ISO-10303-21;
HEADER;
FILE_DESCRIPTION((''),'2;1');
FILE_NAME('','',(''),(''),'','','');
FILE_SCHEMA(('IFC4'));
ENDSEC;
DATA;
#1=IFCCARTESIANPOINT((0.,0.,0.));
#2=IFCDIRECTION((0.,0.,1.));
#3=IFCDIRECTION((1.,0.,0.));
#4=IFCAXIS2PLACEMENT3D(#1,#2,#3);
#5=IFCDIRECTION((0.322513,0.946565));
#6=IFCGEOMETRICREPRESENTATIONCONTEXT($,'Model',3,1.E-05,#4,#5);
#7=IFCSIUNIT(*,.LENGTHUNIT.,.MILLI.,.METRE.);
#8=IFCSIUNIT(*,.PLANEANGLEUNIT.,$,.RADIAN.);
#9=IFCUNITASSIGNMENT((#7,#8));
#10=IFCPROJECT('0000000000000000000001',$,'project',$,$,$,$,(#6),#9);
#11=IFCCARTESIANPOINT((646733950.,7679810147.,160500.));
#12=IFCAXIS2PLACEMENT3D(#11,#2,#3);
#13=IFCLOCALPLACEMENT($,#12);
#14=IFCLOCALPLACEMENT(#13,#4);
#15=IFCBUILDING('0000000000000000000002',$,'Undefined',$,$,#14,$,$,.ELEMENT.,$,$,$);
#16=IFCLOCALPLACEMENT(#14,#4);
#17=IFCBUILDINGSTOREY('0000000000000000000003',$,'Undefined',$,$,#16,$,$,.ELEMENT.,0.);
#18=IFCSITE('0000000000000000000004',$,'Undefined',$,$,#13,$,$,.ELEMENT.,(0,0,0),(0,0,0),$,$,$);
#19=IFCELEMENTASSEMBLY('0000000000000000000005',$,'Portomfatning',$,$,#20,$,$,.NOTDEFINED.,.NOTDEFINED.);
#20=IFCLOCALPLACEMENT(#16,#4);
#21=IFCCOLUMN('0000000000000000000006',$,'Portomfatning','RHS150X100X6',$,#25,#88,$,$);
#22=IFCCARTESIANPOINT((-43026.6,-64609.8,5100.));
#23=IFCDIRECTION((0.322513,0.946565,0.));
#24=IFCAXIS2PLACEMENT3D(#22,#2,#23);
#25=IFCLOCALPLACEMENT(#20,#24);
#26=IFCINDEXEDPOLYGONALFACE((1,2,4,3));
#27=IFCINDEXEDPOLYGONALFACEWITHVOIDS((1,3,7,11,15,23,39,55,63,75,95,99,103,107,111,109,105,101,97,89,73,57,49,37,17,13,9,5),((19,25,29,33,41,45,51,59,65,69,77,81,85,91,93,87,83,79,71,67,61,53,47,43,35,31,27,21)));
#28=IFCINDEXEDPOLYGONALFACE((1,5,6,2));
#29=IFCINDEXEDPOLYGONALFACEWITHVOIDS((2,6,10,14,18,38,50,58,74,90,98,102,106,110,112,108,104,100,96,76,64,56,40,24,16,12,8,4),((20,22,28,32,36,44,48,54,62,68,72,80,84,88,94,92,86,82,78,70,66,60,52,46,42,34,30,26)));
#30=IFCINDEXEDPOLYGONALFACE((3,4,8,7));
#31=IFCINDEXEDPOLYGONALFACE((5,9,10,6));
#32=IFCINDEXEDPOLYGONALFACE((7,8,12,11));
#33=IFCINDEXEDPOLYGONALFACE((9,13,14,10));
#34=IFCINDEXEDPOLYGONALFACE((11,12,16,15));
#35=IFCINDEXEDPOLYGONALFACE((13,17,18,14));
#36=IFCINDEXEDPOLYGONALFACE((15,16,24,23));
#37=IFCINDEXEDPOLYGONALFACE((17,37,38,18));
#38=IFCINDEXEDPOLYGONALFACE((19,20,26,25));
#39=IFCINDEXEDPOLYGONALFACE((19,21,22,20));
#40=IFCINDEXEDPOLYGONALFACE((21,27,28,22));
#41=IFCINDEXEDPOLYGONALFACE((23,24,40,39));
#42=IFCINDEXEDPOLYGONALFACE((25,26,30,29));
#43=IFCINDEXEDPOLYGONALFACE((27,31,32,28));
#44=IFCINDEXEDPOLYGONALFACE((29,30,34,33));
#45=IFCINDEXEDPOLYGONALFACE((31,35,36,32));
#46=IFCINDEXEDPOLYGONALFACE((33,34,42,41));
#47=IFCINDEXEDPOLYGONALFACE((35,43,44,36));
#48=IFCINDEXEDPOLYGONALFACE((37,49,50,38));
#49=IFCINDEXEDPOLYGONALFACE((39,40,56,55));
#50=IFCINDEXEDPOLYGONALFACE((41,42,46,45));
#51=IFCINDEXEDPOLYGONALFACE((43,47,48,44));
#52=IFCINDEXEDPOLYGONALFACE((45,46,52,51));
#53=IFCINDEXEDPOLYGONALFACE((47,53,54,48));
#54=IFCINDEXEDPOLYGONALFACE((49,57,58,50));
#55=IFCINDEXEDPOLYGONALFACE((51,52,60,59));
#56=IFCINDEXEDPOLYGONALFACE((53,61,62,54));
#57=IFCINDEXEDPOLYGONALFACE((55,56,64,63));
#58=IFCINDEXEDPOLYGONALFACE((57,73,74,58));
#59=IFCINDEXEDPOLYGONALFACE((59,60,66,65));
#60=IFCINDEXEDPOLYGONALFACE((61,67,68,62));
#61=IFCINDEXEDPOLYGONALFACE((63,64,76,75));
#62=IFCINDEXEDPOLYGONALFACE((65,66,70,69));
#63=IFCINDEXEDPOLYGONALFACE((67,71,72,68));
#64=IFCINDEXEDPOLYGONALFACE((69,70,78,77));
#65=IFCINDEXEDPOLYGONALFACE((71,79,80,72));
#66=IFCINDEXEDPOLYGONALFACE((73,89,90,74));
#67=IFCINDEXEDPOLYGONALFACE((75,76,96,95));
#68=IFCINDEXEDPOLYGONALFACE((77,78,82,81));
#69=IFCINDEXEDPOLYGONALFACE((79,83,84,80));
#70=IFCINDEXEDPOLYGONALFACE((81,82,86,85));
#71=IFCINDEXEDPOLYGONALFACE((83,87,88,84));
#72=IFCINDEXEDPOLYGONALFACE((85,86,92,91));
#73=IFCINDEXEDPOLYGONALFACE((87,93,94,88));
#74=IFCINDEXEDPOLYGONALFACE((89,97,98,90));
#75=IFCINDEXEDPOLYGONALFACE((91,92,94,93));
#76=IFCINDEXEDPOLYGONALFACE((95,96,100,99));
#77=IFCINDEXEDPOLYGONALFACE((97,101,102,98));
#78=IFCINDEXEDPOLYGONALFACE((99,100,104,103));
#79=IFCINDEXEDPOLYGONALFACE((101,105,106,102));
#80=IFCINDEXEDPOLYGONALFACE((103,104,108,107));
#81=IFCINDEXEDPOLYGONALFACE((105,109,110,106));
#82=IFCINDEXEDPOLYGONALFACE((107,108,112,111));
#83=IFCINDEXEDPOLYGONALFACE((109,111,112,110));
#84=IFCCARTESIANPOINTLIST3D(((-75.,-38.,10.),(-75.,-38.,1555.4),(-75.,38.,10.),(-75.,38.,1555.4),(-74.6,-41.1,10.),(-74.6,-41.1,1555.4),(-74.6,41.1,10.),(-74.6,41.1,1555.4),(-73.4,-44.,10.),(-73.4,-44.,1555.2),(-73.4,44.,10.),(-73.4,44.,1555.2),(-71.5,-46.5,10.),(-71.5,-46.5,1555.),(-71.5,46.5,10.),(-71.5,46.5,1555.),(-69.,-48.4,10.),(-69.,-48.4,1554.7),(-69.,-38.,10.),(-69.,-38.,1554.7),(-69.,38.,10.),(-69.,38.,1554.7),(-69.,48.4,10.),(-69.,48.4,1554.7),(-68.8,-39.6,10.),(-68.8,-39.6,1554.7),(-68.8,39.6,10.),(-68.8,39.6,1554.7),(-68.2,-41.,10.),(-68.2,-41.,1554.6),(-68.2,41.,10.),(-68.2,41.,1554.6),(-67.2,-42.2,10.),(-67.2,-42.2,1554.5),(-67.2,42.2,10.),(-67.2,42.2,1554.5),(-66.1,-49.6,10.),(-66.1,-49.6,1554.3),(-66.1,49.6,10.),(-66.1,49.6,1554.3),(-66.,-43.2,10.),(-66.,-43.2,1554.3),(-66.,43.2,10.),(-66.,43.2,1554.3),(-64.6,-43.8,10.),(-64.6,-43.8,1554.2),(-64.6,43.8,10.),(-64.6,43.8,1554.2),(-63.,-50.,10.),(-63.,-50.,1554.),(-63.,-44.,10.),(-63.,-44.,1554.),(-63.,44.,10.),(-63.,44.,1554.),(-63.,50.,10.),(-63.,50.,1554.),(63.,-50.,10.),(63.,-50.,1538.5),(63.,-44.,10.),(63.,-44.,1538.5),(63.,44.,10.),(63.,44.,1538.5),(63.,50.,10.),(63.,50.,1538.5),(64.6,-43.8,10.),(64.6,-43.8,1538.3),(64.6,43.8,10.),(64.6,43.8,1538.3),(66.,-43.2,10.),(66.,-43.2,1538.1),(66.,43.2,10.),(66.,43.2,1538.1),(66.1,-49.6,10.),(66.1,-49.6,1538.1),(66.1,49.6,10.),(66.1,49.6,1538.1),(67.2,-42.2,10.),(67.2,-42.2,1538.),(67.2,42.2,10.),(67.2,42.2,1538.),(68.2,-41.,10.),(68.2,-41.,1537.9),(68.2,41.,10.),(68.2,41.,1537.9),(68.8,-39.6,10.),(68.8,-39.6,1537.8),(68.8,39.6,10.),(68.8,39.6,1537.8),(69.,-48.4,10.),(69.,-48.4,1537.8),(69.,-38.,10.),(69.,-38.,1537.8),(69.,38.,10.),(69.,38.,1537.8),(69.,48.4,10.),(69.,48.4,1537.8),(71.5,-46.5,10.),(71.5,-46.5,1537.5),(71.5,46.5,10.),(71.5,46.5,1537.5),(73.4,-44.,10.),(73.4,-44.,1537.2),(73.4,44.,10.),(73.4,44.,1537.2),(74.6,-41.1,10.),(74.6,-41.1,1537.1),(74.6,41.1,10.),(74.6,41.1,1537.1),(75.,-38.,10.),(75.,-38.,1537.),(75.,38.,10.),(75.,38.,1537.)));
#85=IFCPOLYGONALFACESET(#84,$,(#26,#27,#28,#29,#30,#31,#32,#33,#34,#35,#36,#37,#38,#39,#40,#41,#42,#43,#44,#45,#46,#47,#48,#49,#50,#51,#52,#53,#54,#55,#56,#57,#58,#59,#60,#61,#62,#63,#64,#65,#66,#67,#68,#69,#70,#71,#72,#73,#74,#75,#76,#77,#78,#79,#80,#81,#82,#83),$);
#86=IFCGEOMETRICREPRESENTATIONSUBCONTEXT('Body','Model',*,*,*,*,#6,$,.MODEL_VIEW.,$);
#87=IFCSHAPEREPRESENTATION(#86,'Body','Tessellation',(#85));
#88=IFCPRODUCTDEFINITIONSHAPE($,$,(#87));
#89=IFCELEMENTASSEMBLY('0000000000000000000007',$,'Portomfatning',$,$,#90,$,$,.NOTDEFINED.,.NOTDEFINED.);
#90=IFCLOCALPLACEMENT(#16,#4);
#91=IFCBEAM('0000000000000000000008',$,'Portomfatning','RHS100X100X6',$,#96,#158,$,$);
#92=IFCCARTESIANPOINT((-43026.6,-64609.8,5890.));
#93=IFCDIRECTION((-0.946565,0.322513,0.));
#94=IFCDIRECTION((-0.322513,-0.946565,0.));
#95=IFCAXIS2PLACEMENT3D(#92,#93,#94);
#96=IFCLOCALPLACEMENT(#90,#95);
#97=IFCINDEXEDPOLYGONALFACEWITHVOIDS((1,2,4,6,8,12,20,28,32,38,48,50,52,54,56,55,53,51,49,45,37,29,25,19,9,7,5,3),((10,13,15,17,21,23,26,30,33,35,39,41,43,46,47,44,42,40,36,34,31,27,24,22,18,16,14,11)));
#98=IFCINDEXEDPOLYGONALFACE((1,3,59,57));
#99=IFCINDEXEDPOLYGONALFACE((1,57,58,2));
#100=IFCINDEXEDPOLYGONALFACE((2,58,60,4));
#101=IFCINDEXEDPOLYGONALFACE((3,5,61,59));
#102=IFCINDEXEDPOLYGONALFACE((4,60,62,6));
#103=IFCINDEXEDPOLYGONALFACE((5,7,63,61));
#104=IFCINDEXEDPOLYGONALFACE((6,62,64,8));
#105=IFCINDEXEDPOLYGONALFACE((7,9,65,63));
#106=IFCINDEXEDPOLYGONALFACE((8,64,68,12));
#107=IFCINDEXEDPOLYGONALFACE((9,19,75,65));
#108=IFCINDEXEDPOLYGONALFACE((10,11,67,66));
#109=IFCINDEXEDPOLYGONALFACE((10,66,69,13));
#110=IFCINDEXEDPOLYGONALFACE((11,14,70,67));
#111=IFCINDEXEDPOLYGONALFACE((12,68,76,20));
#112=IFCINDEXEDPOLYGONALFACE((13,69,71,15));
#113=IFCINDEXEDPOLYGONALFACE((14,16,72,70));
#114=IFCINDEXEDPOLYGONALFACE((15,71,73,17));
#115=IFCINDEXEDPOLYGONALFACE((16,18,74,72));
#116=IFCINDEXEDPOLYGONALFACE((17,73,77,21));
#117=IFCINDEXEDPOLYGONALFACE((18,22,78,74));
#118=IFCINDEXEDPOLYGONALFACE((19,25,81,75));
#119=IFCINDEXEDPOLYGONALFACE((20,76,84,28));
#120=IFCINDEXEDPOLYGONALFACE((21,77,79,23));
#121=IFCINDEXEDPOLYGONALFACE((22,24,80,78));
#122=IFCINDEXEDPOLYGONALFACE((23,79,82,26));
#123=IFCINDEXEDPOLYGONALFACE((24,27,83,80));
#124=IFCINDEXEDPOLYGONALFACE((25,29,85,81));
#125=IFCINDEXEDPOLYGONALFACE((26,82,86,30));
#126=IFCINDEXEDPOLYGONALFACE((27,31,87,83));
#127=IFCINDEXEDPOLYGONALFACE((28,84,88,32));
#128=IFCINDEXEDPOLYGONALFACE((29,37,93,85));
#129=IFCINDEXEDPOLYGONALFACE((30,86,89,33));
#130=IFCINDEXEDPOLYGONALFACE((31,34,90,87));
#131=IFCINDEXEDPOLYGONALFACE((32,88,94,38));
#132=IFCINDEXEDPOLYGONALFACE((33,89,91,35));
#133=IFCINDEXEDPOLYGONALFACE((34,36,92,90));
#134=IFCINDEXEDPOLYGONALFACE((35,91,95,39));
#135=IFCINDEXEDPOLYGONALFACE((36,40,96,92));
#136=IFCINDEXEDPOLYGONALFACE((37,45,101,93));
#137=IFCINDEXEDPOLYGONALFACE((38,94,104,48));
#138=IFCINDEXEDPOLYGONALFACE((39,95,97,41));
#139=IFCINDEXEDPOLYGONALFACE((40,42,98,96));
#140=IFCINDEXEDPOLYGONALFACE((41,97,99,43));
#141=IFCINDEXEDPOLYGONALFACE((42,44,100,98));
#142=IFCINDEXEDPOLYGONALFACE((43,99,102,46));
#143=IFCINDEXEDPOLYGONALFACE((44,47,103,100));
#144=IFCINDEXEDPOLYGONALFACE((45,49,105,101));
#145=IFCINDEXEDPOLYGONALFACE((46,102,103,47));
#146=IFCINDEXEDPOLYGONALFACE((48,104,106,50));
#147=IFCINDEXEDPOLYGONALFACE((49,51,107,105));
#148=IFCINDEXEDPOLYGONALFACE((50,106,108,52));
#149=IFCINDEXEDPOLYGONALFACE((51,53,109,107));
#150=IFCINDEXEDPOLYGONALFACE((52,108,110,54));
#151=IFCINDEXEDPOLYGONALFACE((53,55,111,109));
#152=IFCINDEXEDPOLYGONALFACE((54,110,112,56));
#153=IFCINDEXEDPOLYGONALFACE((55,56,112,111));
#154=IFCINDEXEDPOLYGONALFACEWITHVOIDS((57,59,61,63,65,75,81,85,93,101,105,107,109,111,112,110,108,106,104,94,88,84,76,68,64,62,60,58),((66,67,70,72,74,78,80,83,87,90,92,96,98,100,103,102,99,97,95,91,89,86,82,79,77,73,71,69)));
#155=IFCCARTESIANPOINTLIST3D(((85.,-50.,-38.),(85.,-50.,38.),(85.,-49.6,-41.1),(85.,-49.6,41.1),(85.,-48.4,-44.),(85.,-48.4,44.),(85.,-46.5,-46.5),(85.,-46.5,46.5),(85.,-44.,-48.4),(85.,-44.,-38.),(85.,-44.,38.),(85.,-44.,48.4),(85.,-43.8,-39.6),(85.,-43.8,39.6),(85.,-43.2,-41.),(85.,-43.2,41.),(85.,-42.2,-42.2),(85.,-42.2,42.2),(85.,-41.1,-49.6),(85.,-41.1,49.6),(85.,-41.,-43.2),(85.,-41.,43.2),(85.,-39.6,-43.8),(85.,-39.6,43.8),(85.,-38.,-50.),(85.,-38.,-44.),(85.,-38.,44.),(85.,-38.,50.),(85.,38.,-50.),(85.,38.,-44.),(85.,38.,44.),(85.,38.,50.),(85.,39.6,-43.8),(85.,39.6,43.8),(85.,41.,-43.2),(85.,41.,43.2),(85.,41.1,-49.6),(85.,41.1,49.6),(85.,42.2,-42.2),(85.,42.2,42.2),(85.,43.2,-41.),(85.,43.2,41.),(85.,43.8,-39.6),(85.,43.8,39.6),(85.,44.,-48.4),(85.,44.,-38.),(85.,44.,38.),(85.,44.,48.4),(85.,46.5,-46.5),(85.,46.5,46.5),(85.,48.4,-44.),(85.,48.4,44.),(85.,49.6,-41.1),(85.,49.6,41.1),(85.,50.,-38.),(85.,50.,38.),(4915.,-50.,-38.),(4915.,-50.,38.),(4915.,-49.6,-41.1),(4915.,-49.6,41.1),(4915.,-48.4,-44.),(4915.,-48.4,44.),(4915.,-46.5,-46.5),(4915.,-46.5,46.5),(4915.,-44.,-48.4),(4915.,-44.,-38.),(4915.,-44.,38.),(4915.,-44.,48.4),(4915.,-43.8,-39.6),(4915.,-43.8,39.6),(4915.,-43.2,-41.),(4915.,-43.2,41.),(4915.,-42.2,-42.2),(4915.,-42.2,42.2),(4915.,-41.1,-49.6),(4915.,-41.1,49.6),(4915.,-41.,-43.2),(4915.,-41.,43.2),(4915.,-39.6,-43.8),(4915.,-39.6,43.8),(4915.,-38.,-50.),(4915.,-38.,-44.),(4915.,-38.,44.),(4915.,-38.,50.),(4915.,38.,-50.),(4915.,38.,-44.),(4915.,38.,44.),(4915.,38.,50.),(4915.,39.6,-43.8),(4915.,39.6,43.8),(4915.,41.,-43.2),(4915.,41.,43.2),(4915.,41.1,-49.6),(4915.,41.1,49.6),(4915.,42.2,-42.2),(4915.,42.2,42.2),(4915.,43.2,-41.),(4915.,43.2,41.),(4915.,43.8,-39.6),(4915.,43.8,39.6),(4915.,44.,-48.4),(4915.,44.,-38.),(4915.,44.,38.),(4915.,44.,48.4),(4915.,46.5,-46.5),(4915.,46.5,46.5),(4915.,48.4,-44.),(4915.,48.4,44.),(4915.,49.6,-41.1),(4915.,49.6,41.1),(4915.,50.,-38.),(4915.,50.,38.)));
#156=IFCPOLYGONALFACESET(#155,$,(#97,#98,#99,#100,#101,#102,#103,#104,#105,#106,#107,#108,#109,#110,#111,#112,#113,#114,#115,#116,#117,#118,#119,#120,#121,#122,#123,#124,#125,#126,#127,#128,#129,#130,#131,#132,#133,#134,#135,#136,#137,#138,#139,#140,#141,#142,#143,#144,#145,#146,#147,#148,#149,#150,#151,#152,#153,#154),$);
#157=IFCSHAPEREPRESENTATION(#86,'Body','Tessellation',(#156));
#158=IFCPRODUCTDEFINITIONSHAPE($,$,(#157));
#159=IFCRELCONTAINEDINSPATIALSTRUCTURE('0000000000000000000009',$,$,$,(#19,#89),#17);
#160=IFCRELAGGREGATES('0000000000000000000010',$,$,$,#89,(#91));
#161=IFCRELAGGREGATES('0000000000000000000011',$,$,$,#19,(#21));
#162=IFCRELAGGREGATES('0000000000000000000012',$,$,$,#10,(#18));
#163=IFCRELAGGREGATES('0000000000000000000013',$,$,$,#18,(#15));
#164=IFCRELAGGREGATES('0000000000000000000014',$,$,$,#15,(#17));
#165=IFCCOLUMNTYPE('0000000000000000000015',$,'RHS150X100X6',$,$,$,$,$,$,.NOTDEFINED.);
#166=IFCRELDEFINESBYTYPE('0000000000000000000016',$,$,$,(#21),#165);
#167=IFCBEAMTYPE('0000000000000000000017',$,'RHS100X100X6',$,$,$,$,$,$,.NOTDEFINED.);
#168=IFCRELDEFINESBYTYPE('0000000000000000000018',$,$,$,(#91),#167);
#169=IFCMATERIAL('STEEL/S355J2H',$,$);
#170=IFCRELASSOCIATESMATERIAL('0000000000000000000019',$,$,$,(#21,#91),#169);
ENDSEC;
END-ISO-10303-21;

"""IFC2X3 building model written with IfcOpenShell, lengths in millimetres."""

from ifc_helpers import new_model, si_unit, direction, frame, origin_with_axes, origin_2d_with_axis, place, context, subcontext, project, spatial, hollow_rectangle, extrude, clip, halfspace, material, type_object, element, aggregate, save


model = new_model("IFC2X3")

# Units and contexts
model_context = context("Model", 3, precision=1e-05, world=origin_with_axes(), true_north=direction((0.322513, 0.946565)))
body_context = subcontext(model_context, "Body", "Model", "MODEL_VIEW")
ifc_project = project(units=[si_unit("LENGTHUNIT", "METRE", prefix="MILLI"), si_unit("PLANEANGLEUNIT", "RADIAN")], contexts=[model_context])

# Site, building, storey
site_placement = place(None, frame((646733950.0, 7679810147.0, 160500.0), z_axis=(0.0, 0.0, 1.0), x_axis=(1.0, 0.0, 0.0)))
site = spatial("IfcSite", under=ifc_project, at=site_placement, Name="Undefined", CompositionType="ELEMENT", RefLatitude=(0, 0, 0), RefLongitude=(0, 0, 0))
building_placement = place(site_placement, origin_with_axes())
building = spatial("IfcBuilding", under=site, at=building_placement, Name="Undefined", CompositionType="ELEMENT")
storey_placement = place(building_placement, origin_with_axes())
storey = spatial("IfcBuildingStorey", under=building, at=storey_placement, Name="Undefined", CompositionType="ELEMENT", Elevation=0.0)

# Element assembly, column
assembly_1_placement = place(storey_placement, origin_with_axes())
assembly_1 = element("IfcElementAssembly", 1, at=assembly_1_placement, inside=storey, Name="Portomfatning", AssemblyPlace="NOTDEFINED", PredefinedType="NOTDEFINED")
ifc_material_1 = material(Name="STEEL/S355J2H")
column_type = type_object("IfcColumnType", Name="RHS150X100X6", PredefinedType="NOTDEFINED")
column_placement = place(assembly_1_placement, frame((-43026.6, -64609.8, 5100.0), z_axis=(0.0, 0.0, 1.0), x_axis=(0.322513, 0.946565, 0.0)))
column = element("IfcColumn", 2, at=column_placement, type_object=column_type, material=ifc_material_1, Name="Portomfatning", Description="RHS150X100X6", context=body_context, shape_type="Clipping", body=[
    clip(clip(extrude(hollow_rectangle(XDim=100.0, YDim=150.0, WallThickness=6.0, InnerFilletRadius=6.0, OuterFilletRadius=12.0, at=origin_2d_with_axis()), frame((0.0, 0.0, 1561.3), z_axis=(0.0, 0.0, -1.0), x_axis=(0.0, 1.0, 0.0)), (0.0, 0.0, 1.0), 1561.3), halfspace(frame((75.0, 0.0, 1537.0), z_axis=(-0.121869, 0.0, -0.992546), x_axis=(0.0, 1.0, 0.0)), True)), halfspace(frame((-75.0, 0.0, 10.0), z_axis=(0.0, 0.0, 1.0), x_axis=(1.0, 0.0, 0.0)), True)),
])

# Element assembly, beam
beam_type_1 = type_object("IfcBeamType", Name="RHS100X100X6", PredefinedType="NOTDEFINED")
assembly_2_placement = place(storey_placement, origin_with_axes())
assembly_2 = element("IfcElementAssembly", 3, at=assembly_2_placement, inside=storey, Name="Portomfatning", AssemblyPlace="NOTDEFINED", PredefinedType="NOTDEFINED")
beam_1_placement = place(assembly_2_placement, frame((-43026.6, -64609.8, 5890.0), z_axis=(-0.946565, 0.322513, 0.0), x_axis=(-0.322513, -0.946565, 0.0)))
beam_1 = element("IfcBeam", 4, at=beam_1_placement, type_object=beam_type_1, material=ifc_material_1, Name="Portomfatning", Description="RHS100X100X6", context=body_context, shape_type="Clipping", body=[
    clip(clip(extrude(hollow_rectangle(XDim=100.0, YDim=100.0, WallThickness=6.0, InnerFilletRadius=6.0, OuterFilletRadius=12.0, at=origin_2d_with_axis()), frame((5000.0, 0.0, 0.0), z_axis=(-1.0, 0.0, 0.0), x_axis=(0.0, -1.0, 0.0)), (0.0, 0.0, 1.0), 5000.0), halfspace(frame((4915.0, -50.0, 0.0), z_axis=(-1.0, 0.0, 0.0), x_axis=(0.0, 0.0, -1.0)), True)), halfspace(frame((85.0, -50.0, 0.0), z_axis=(1.0, 0.0, 0.0), x_axis=(0.0, 0.0, 1.0)), True)),
])

aggregate(assembly_2, [beam_1])

aggregate(assembly_1, [column])

save(model, "model.ifc")
